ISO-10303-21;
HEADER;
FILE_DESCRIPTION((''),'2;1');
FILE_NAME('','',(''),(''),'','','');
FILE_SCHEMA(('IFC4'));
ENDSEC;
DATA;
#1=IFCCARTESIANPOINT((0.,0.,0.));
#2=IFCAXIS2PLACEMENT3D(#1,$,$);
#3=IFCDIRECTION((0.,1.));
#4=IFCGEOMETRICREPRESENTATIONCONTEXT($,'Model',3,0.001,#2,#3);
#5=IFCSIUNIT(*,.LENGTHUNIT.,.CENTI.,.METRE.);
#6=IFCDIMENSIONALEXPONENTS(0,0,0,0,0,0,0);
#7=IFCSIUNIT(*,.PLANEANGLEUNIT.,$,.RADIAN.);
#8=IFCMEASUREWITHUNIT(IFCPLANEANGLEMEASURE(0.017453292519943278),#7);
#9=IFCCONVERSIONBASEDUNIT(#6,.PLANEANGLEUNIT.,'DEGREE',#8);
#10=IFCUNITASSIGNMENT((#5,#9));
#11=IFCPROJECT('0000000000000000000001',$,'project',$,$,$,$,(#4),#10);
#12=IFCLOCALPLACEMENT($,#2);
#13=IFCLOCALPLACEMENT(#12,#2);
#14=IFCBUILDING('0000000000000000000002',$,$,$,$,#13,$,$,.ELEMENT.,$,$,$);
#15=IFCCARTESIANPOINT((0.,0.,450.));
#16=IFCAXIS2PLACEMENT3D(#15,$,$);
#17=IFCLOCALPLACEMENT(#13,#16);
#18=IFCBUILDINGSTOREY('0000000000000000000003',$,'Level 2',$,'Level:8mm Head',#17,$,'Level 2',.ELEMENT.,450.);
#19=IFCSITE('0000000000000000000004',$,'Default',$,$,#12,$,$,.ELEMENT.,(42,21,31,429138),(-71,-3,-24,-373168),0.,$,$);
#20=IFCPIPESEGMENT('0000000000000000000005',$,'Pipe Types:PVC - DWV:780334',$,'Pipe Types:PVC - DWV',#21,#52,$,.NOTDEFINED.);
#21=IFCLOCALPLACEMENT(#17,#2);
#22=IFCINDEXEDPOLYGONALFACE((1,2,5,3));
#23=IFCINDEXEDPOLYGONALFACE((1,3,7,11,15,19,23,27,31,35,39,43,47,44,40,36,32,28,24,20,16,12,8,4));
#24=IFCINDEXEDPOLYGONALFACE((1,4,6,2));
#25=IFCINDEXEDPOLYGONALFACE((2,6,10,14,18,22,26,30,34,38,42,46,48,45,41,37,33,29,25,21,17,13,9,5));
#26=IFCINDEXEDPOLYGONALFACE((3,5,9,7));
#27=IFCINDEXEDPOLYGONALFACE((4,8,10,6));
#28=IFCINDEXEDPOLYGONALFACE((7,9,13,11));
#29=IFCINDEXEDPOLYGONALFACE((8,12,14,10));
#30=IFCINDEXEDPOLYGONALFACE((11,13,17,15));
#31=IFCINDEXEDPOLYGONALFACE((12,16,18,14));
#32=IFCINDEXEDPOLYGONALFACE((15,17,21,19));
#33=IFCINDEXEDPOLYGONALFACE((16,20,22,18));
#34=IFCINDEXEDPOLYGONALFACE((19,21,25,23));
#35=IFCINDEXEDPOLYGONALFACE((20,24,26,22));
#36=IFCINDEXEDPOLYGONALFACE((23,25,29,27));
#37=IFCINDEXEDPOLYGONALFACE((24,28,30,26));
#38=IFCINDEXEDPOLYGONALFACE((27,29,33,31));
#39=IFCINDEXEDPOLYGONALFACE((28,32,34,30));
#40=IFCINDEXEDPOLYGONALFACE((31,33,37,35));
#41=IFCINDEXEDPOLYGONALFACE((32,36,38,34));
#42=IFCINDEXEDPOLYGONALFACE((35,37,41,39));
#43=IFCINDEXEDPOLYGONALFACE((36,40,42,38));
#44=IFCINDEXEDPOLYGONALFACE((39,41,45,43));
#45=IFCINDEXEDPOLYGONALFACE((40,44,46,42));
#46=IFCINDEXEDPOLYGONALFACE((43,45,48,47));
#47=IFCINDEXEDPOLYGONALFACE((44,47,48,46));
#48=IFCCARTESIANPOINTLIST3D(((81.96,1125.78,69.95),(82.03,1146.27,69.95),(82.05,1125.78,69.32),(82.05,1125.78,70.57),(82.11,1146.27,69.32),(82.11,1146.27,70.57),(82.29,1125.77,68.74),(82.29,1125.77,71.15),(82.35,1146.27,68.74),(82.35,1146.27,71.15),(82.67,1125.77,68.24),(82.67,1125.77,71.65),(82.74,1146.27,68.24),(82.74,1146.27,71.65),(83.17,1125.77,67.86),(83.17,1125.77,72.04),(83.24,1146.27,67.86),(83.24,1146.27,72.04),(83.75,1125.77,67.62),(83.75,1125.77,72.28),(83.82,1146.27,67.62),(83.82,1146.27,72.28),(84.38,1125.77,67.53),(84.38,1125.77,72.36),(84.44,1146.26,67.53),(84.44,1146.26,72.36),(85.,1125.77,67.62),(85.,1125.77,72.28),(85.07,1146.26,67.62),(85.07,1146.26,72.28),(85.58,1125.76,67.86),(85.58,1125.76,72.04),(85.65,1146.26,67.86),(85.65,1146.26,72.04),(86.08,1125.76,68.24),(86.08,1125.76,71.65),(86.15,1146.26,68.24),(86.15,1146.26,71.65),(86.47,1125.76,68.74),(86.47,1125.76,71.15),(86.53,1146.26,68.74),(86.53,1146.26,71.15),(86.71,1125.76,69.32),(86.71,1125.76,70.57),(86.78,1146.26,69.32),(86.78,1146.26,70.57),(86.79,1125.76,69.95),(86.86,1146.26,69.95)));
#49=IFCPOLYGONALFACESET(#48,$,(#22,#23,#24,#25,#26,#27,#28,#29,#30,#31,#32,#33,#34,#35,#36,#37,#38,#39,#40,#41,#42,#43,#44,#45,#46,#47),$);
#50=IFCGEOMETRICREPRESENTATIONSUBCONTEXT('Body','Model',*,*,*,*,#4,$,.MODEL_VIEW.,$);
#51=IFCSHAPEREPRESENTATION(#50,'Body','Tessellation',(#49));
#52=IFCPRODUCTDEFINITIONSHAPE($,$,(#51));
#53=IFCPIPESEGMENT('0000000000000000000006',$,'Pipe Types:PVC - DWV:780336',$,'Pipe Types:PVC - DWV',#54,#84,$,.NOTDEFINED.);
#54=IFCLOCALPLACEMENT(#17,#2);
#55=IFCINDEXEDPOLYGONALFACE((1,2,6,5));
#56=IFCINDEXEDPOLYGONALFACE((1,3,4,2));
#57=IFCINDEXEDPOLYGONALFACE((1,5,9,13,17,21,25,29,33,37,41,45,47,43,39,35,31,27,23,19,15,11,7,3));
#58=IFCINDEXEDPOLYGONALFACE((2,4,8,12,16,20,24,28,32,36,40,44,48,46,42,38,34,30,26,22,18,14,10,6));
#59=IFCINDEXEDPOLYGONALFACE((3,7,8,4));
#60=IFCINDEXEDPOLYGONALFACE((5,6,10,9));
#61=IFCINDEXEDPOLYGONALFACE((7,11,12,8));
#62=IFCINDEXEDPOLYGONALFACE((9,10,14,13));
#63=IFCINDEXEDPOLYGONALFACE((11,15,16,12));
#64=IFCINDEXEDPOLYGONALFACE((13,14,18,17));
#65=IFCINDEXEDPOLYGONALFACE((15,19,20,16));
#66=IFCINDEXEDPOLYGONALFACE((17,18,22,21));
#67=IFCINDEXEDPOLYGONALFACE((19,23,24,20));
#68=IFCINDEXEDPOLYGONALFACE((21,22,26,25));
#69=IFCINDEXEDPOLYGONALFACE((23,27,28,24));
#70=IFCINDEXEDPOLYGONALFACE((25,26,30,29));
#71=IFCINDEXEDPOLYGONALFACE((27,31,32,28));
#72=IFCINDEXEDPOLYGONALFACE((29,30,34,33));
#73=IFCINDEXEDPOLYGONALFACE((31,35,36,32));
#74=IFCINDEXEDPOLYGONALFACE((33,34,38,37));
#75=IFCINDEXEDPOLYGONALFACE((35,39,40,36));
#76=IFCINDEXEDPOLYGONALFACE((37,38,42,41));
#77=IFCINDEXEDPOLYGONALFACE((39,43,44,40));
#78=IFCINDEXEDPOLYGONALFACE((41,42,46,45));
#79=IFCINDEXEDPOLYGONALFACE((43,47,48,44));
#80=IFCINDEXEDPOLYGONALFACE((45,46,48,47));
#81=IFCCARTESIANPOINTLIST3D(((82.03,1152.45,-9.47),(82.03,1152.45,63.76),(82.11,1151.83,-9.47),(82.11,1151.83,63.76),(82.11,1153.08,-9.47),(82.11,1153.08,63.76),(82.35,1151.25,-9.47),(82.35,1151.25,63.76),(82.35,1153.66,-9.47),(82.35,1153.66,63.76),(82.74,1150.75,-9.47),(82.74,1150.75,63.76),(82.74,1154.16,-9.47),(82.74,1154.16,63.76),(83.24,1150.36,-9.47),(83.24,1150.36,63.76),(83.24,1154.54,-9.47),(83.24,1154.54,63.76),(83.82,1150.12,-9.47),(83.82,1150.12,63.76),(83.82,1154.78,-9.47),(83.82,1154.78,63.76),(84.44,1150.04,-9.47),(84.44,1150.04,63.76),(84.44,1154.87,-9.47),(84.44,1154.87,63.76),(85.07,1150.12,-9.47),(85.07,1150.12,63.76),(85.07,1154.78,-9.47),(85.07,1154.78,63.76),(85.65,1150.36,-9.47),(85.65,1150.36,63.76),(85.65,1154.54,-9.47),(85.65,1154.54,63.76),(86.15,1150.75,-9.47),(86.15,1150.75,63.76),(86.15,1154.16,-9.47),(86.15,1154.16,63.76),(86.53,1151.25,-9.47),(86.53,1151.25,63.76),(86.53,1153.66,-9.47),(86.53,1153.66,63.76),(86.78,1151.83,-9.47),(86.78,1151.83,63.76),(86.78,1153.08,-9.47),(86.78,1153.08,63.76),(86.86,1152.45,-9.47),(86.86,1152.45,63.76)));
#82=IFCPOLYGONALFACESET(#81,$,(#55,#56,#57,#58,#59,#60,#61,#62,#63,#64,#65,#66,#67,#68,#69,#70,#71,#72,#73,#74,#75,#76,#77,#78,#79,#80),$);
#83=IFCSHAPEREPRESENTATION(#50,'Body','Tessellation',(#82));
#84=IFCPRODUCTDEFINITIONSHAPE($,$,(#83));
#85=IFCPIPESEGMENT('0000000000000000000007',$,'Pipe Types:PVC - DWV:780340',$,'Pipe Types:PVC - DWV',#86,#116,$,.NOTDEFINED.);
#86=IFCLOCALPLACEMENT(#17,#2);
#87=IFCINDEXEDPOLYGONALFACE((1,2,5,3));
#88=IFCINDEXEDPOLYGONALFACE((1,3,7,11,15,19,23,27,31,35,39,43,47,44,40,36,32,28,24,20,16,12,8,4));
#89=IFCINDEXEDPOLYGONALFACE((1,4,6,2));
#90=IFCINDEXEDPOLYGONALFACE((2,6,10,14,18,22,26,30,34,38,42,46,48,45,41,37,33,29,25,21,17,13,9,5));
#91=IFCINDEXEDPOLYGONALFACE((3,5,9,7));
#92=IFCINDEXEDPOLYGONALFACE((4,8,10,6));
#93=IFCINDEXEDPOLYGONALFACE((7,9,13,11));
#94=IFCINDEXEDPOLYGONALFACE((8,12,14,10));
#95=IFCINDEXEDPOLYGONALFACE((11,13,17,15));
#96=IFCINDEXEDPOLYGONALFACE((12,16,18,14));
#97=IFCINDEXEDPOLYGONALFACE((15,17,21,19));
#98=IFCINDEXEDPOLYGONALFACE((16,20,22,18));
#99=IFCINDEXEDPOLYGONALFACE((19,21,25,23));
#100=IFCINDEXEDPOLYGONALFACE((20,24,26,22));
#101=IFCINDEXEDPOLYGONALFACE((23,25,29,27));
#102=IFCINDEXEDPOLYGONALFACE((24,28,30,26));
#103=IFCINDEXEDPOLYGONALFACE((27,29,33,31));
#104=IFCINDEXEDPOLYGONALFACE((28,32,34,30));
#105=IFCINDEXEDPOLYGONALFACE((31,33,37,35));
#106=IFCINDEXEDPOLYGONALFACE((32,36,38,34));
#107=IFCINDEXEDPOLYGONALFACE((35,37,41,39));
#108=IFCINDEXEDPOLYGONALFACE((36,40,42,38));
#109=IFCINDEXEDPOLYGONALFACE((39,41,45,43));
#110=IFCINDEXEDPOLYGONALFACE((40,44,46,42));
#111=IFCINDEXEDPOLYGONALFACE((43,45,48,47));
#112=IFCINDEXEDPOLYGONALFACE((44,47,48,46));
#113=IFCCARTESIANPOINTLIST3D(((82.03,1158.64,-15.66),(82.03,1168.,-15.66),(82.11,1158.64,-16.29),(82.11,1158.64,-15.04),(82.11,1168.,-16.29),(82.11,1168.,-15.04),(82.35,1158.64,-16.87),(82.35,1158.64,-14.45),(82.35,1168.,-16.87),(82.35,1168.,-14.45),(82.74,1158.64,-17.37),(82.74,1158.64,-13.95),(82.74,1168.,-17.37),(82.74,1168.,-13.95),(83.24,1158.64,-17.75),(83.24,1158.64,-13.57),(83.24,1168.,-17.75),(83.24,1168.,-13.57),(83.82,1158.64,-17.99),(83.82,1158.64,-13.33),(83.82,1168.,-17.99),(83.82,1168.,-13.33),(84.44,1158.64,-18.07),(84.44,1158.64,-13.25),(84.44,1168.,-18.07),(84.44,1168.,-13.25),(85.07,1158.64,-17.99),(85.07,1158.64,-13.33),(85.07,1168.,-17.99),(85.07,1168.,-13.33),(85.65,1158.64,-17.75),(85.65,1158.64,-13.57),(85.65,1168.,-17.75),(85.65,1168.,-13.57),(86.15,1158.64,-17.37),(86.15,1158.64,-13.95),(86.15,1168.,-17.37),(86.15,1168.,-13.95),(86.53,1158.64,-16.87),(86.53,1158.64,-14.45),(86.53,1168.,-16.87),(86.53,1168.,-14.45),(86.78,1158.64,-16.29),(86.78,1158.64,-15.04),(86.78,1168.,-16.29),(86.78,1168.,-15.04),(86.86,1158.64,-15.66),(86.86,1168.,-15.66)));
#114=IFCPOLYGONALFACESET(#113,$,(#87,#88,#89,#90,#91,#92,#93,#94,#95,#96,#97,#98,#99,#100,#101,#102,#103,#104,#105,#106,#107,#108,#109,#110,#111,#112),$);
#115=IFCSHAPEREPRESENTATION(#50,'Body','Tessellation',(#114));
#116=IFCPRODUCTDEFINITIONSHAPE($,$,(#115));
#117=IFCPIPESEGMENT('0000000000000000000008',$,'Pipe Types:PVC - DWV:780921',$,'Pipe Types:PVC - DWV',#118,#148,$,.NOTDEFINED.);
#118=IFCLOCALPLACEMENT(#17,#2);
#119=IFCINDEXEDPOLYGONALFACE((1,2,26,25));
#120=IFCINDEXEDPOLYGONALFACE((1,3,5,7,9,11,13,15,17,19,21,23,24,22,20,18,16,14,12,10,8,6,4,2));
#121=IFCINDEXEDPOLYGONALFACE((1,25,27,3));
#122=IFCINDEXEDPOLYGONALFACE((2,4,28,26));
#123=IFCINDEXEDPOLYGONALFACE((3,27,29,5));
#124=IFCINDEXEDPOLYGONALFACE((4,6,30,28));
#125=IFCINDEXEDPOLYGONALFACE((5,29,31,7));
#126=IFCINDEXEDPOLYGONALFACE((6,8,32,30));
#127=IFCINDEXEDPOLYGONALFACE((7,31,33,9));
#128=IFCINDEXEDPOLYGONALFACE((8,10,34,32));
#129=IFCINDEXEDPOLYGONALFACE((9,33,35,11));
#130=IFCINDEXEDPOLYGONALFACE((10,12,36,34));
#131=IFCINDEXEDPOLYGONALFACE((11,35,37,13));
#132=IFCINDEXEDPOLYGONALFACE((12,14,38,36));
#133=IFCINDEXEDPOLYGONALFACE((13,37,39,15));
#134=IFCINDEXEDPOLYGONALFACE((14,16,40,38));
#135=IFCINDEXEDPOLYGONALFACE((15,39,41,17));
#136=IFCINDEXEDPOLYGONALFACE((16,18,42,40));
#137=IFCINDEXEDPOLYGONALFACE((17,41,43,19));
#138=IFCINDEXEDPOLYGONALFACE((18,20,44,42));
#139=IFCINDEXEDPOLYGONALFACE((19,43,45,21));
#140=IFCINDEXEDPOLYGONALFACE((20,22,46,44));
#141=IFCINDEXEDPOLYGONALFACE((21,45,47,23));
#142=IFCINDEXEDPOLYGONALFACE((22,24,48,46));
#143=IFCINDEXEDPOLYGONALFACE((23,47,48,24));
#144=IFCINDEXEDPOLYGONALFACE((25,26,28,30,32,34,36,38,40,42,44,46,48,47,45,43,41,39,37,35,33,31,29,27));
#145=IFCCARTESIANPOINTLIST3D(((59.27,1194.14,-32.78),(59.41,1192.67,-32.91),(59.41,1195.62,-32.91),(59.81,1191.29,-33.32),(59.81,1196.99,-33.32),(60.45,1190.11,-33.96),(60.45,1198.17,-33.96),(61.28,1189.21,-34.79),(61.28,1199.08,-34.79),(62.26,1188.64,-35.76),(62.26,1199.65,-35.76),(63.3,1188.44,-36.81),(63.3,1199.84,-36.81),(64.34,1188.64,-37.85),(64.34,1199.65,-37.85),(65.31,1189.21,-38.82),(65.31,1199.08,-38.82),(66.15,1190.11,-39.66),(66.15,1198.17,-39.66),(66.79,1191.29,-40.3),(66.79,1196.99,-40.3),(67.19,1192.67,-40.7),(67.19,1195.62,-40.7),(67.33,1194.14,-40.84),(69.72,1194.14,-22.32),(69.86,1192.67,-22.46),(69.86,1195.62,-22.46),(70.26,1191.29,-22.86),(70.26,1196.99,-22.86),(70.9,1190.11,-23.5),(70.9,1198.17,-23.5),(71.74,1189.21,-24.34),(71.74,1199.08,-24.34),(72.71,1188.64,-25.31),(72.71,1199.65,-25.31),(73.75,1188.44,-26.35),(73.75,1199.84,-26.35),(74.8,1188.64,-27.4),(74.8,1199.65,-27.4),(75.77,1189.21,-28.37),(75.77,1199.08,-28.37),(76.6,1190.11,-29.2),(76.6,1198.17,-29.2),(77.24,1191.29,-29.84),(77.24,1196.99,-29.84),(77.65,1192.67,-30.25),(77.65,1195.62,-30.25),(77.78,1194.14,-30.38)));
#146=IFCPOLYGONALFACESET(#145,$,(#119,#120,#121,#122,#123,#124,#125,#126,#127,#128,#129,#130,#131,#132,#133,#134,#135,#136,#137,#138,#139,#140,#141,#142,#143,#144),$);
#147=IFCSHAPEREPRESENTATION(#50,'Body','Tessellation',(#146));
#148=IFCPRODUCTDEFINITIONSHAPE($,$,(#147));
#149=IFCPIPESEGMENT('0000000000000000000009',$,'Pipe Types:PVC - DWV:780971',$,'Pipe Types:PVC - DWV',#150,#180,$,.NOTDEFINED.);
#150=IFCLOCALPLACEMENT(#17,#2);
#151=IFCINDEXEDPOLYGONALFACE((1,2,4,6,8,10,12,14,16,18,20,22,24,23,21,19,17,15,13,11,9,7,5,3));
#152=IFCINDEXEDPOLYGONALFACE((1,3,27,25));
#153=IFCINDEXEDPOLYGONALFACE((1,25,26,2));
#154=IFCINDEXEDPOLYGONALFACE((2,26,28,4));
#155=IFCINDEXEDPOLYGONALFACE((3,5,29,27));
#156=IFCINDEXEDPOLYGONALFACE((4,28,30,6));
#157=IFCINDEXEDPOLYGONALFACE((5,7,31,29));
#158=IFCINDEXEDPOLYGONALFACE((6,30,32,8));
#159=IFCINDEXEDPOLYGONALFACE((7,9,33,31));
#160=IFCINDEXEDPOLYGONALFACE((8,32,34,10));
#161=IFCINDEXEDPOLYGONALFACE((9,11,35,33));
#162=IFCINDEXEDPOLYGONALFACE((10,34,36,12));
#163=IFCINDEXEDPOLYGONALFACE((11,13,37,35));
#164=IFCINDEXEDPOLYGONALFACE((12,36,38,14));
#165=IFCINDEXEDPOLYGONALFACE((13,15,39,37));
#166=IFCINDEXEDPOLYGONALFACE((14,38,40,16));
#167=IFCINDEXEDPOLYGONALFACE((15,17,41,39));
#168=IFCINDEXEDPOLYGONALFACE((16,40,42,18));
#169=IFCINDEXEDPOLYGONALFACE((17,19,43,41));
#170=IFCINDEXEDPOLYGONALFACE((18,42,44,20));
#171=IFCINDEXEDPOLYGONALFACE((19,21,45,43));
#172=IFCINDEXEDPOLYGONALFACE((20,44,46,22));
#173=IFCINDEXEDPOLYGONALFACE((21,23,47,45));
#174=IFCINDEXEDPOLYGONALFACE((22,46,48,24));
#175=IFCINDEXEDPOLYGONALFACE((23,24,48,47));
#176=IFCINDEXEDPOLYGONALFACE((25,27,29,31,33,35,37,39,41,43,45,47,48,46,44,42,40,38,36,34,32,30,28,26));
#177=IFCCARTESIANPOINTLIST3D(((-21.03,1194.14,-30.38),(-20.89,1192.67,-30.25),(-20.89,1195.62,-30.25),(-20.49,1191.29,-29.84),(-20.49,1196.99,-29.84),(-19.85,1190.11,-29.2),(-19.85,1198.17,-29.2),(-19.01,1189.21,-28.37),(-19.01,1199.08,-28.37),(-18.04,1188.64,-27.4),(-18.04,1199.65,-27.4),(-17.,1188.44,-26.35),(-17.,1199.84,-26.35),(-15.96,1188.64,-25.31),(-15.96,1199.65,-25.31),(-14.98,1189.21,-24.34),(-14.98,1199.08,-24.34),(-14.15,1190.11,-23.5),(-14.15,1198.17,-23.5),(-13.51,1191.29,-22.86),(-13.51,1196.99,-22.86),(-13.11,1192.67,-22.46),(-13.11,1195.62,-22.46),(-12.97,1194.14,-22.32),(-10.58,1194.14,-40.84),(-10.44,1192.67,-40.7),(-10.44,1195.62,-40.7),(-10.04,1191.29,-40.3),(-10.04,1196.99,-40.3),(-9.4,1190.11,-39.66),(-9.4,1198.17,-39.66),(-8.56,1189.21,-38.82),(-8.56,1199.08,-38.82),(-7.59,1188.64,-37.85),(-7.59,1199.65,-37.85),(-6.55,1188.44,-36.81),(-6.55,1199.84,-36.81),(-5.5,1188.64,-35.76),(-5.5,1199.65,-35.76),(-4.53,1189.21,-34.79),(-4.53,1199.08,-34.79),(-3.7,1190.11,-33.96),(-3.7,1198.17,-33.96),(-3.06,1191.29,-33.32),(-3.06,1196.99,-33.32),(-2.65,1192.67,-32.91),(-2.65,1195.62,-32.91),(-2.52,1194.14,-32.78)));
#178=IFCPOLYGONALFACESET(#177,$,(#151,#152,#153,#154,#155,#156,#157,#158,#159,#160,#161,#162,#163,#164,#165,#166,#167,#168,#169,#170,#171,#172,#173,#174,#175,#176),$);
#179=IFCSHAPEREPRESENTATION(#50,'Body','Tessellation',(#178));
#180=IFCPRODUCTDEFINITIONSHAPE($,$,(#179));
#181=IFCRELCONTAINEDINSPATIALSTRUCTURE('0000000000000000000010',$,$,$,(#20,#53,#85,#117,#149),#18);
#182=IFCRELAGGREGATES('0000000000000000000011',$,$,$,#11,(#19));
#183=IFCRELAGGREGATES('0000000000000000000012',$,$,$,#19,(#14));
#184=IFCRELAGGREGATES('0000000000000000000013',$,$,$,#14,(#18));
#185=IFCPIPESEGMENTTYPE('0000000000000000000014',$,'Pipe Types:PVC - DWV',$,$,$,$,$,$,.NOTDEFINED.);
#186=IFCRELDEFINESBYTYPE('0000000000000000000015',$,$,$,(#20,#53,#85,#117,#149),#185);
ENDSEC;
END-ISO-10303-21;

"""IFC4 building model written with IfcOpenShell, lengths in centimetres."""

from ifc_helpers import new_model, entity, si_unit, converted_unit, direction, frame, origin, place, context, subcontext, project, spatial, arc, indexed_curve, outline, extrude, type_object, element, save


model = new_model("IFC4")

# Units and contexts
model_context = context("Model", 3, precision=0.001, world=origin(), true_north=direction((0.0, 1.0)))
body_context = subcontext(model_context, "Body", "Model", "MODEL_VIEW")
ifc_project = project(units=[si_unit("LENGTHUNIT", "METRE", prefix="CENTI"), converted_unit("PLANEANGLEUNIT", "DEGREE", entity("IfcPlaneAngleMeasure", 0.017453292519943278), si_unit("PLANEANGLEUNIT", "RADIAN"), dimensions=[0, 0, 0, 0, 0, 0, 0])], contexts=[model_context])

# Site, building, storey
site_placement = place(None, origin())
site = spatial("IfcSite", under=ifc_project, at=site_placement, Name="Default", CompositionType="ELEMENT", RefLatitude=(42, 21, 31, 429138), RefLongitude=(-71, -3, -24, -373168), RefElevation=0.0)
building_placement = place(site_placement, origin())
building = spatial("IfcBuilding", under=site, at=building_placement, CompositionType="ELEMENT")
storey_placement = place(building_placement, frame((0.0, 0.0, 450.0)))
storey = spatial("IfcBuildingStorey", under=building, at=storey_placement, Name="Level 2", ObjectType="Level:8mm Head", LongName="Level 2", CompositionType="ELEMENT", Elevation=450.0)

# Pipe segments
pipe_segment_type = type_object("IfcPipeSegmentType", Name="Pipe Types:PVC - DWV", PredefinedType="NOTDEFINED")
pipe_segment_1_placement = place(storey_placement, origin())
element("IfcPipeSegment", 1, at=pipe_segment_1_placement, inside=storey, type_object=pipe_segment_type, Name="Pipe Types:PVC - DWV:780334", ObjectType="Pipe Types:PVC - DWV", PredefinedType="NOTDEFINED", context=body_context, shape_type="SweptSolid", body=[
    extrude(outline(indexed_curve([(2.41, 0.0), (1.71, 1.71), (0.0, 2.41), (-1.71, 1.71), (-2.41, 0.0), (-1.71, -1.71), (0.0, -2.41), (1.71, -1.71)], segments=[arc(1, 2, 3), arc(3, 4, 5), arc(5, 6, 7), arc(7, 8, 1)], self_intersect=False)), frame((84.38, 1125.77, 69.95), z_axis=(0.003331, 0.999994, 0.0), x_axis=(0.999994, -0.003331, 0.0)), (0.0, 0.0, 1.0), 20.5),
])
pipe_segment_2_placement = place(storey_placement, origin())
element("IfcPipeSegment", 2, at=pipe_segment_2_placement, inside=storey, type_object=pipe_segment_type, Name="Pipe Types:PVC - DWV:780336", ObjectType="Pipe Types:PVC - DWV", PredefinedType="NOTDEFINED", context=body_context, shape_type="SweptSolid", body=[
    extrude(outline(indexed_curve([(2.41, 0.0), (1.71, 1.71), (0.0, 2.41), (-1.71, 1.71), (-2.41, 0.0), (-1.71, -1.71), (0.0, -2.41), (1.71, -1.71)], segments=[arc(1, 2, 3), arc(3, 4, 5), arc(5, 6, 7), arc(7, 8, 1)], self_intersect=False)), frame((84.44, 1152.45, -9.47)), (0.0, 0.0, 1.0), 73.23),
])
pipe_segment_3_placement = place(storey_placement, origin())
element("IfcPipeSegment", 3, at=pipe_segment_3_placement, inside=storey, type_object=pipe_segment_type, Name="Pipe Types:PVC - DWV:780340", ObjectType="Pipe Types:PVC - DWV", PredefinedType="NOTDEFINED", context=body_context, shape_type="SweptSolid", body=[
    extrude(outline(indexed_curve([(2.41, 0.0), (1.71, 1.71), (0.0, 2.41), (-1.71, 1.71), (-2.41, 0.0), (-1.71, -1.71), (0.0, -2.41), (1.71, -1.71)], segments=[arc(1, 2, 3), arc(3, 4, 5), arc(5, 6, 7), arc(7, 8, 1)], self_intersect=False)), frame((84.44, 1158.64, -15.66), z_axis=(0.0, 1.0, 0.0), x_axis=(1.0, 0.0, 0.0)), (0.0, 0.0, 1.0), 9.36),
])
pipe_segment_4_placement = place(storey_placement, origin())
element("IfcPipeSegment", 4, at=pipe_segment_4_placement, inside=storey, type_object=pipe_segment_type, Name="Pipe Types:PVC - DWV:780921", ObjectType="Pipe Types:PVC - DWV", PredefinedType="NOTDEFINED", context=body_context, shape_type="SweptSolid", body=[
    extrude(outline(indexed_curve([(5.7, 0.0), (4.03, 4.03), (0.0, 5.7), (-4.03, 4.03), (-5.7, 0.0), (-4.03, -4.03), (0.0, -5.7), (4.03, -4.03)], segments=[arc(1, 2, 3), arc(3, 4, 5), arc(5, 6, 7), arc(7, 8, 1)], self_intersect=False)), frame((63.3, 1194.14, -36.81), z_axis=(0.707107, 0.0, 0.707107), x_axis=(0.0, -1.0, 0.0)), (0.0, 0.0, 1.0), 14.78),
])
pipe_segment_5_placement = place(storey_placement, origin())
element("IfcPipeSegment", 5, at=pipe_segment_5_placement, inside=storey, type_object=pipe_segment_type, Name="Pipe Types:PVC - DWV:780971", ObjectType="Pipe Types:PVC - DWV", PredefinedType="NOTDEFINED", context=body_context, shape_type="SweptSolid", body=[
    extrude(outline(indexed_curve([(5.7, 0.0), (4.03, 4.03), (0.0, 5.7), (-4.03, 4.03), (-5.7, 0.0), (-4.03, -4.03), (0.0, -5.7), (4.03, -4.03)], segments=[arc(1, 2, 3), arc(3, 4, 5), arc(5, 6, 7), arc(7, 8, 1)], self_intersect=False)), frame((-17.0, 1194.14, -26.35), z_axis=(0.707107, 0.0, -0.707107), x_axis=(0.0, -1.0, 0.0)), (0.0, 0.0, 1.0), 14.78),
])

save(model, "model.ifc")
